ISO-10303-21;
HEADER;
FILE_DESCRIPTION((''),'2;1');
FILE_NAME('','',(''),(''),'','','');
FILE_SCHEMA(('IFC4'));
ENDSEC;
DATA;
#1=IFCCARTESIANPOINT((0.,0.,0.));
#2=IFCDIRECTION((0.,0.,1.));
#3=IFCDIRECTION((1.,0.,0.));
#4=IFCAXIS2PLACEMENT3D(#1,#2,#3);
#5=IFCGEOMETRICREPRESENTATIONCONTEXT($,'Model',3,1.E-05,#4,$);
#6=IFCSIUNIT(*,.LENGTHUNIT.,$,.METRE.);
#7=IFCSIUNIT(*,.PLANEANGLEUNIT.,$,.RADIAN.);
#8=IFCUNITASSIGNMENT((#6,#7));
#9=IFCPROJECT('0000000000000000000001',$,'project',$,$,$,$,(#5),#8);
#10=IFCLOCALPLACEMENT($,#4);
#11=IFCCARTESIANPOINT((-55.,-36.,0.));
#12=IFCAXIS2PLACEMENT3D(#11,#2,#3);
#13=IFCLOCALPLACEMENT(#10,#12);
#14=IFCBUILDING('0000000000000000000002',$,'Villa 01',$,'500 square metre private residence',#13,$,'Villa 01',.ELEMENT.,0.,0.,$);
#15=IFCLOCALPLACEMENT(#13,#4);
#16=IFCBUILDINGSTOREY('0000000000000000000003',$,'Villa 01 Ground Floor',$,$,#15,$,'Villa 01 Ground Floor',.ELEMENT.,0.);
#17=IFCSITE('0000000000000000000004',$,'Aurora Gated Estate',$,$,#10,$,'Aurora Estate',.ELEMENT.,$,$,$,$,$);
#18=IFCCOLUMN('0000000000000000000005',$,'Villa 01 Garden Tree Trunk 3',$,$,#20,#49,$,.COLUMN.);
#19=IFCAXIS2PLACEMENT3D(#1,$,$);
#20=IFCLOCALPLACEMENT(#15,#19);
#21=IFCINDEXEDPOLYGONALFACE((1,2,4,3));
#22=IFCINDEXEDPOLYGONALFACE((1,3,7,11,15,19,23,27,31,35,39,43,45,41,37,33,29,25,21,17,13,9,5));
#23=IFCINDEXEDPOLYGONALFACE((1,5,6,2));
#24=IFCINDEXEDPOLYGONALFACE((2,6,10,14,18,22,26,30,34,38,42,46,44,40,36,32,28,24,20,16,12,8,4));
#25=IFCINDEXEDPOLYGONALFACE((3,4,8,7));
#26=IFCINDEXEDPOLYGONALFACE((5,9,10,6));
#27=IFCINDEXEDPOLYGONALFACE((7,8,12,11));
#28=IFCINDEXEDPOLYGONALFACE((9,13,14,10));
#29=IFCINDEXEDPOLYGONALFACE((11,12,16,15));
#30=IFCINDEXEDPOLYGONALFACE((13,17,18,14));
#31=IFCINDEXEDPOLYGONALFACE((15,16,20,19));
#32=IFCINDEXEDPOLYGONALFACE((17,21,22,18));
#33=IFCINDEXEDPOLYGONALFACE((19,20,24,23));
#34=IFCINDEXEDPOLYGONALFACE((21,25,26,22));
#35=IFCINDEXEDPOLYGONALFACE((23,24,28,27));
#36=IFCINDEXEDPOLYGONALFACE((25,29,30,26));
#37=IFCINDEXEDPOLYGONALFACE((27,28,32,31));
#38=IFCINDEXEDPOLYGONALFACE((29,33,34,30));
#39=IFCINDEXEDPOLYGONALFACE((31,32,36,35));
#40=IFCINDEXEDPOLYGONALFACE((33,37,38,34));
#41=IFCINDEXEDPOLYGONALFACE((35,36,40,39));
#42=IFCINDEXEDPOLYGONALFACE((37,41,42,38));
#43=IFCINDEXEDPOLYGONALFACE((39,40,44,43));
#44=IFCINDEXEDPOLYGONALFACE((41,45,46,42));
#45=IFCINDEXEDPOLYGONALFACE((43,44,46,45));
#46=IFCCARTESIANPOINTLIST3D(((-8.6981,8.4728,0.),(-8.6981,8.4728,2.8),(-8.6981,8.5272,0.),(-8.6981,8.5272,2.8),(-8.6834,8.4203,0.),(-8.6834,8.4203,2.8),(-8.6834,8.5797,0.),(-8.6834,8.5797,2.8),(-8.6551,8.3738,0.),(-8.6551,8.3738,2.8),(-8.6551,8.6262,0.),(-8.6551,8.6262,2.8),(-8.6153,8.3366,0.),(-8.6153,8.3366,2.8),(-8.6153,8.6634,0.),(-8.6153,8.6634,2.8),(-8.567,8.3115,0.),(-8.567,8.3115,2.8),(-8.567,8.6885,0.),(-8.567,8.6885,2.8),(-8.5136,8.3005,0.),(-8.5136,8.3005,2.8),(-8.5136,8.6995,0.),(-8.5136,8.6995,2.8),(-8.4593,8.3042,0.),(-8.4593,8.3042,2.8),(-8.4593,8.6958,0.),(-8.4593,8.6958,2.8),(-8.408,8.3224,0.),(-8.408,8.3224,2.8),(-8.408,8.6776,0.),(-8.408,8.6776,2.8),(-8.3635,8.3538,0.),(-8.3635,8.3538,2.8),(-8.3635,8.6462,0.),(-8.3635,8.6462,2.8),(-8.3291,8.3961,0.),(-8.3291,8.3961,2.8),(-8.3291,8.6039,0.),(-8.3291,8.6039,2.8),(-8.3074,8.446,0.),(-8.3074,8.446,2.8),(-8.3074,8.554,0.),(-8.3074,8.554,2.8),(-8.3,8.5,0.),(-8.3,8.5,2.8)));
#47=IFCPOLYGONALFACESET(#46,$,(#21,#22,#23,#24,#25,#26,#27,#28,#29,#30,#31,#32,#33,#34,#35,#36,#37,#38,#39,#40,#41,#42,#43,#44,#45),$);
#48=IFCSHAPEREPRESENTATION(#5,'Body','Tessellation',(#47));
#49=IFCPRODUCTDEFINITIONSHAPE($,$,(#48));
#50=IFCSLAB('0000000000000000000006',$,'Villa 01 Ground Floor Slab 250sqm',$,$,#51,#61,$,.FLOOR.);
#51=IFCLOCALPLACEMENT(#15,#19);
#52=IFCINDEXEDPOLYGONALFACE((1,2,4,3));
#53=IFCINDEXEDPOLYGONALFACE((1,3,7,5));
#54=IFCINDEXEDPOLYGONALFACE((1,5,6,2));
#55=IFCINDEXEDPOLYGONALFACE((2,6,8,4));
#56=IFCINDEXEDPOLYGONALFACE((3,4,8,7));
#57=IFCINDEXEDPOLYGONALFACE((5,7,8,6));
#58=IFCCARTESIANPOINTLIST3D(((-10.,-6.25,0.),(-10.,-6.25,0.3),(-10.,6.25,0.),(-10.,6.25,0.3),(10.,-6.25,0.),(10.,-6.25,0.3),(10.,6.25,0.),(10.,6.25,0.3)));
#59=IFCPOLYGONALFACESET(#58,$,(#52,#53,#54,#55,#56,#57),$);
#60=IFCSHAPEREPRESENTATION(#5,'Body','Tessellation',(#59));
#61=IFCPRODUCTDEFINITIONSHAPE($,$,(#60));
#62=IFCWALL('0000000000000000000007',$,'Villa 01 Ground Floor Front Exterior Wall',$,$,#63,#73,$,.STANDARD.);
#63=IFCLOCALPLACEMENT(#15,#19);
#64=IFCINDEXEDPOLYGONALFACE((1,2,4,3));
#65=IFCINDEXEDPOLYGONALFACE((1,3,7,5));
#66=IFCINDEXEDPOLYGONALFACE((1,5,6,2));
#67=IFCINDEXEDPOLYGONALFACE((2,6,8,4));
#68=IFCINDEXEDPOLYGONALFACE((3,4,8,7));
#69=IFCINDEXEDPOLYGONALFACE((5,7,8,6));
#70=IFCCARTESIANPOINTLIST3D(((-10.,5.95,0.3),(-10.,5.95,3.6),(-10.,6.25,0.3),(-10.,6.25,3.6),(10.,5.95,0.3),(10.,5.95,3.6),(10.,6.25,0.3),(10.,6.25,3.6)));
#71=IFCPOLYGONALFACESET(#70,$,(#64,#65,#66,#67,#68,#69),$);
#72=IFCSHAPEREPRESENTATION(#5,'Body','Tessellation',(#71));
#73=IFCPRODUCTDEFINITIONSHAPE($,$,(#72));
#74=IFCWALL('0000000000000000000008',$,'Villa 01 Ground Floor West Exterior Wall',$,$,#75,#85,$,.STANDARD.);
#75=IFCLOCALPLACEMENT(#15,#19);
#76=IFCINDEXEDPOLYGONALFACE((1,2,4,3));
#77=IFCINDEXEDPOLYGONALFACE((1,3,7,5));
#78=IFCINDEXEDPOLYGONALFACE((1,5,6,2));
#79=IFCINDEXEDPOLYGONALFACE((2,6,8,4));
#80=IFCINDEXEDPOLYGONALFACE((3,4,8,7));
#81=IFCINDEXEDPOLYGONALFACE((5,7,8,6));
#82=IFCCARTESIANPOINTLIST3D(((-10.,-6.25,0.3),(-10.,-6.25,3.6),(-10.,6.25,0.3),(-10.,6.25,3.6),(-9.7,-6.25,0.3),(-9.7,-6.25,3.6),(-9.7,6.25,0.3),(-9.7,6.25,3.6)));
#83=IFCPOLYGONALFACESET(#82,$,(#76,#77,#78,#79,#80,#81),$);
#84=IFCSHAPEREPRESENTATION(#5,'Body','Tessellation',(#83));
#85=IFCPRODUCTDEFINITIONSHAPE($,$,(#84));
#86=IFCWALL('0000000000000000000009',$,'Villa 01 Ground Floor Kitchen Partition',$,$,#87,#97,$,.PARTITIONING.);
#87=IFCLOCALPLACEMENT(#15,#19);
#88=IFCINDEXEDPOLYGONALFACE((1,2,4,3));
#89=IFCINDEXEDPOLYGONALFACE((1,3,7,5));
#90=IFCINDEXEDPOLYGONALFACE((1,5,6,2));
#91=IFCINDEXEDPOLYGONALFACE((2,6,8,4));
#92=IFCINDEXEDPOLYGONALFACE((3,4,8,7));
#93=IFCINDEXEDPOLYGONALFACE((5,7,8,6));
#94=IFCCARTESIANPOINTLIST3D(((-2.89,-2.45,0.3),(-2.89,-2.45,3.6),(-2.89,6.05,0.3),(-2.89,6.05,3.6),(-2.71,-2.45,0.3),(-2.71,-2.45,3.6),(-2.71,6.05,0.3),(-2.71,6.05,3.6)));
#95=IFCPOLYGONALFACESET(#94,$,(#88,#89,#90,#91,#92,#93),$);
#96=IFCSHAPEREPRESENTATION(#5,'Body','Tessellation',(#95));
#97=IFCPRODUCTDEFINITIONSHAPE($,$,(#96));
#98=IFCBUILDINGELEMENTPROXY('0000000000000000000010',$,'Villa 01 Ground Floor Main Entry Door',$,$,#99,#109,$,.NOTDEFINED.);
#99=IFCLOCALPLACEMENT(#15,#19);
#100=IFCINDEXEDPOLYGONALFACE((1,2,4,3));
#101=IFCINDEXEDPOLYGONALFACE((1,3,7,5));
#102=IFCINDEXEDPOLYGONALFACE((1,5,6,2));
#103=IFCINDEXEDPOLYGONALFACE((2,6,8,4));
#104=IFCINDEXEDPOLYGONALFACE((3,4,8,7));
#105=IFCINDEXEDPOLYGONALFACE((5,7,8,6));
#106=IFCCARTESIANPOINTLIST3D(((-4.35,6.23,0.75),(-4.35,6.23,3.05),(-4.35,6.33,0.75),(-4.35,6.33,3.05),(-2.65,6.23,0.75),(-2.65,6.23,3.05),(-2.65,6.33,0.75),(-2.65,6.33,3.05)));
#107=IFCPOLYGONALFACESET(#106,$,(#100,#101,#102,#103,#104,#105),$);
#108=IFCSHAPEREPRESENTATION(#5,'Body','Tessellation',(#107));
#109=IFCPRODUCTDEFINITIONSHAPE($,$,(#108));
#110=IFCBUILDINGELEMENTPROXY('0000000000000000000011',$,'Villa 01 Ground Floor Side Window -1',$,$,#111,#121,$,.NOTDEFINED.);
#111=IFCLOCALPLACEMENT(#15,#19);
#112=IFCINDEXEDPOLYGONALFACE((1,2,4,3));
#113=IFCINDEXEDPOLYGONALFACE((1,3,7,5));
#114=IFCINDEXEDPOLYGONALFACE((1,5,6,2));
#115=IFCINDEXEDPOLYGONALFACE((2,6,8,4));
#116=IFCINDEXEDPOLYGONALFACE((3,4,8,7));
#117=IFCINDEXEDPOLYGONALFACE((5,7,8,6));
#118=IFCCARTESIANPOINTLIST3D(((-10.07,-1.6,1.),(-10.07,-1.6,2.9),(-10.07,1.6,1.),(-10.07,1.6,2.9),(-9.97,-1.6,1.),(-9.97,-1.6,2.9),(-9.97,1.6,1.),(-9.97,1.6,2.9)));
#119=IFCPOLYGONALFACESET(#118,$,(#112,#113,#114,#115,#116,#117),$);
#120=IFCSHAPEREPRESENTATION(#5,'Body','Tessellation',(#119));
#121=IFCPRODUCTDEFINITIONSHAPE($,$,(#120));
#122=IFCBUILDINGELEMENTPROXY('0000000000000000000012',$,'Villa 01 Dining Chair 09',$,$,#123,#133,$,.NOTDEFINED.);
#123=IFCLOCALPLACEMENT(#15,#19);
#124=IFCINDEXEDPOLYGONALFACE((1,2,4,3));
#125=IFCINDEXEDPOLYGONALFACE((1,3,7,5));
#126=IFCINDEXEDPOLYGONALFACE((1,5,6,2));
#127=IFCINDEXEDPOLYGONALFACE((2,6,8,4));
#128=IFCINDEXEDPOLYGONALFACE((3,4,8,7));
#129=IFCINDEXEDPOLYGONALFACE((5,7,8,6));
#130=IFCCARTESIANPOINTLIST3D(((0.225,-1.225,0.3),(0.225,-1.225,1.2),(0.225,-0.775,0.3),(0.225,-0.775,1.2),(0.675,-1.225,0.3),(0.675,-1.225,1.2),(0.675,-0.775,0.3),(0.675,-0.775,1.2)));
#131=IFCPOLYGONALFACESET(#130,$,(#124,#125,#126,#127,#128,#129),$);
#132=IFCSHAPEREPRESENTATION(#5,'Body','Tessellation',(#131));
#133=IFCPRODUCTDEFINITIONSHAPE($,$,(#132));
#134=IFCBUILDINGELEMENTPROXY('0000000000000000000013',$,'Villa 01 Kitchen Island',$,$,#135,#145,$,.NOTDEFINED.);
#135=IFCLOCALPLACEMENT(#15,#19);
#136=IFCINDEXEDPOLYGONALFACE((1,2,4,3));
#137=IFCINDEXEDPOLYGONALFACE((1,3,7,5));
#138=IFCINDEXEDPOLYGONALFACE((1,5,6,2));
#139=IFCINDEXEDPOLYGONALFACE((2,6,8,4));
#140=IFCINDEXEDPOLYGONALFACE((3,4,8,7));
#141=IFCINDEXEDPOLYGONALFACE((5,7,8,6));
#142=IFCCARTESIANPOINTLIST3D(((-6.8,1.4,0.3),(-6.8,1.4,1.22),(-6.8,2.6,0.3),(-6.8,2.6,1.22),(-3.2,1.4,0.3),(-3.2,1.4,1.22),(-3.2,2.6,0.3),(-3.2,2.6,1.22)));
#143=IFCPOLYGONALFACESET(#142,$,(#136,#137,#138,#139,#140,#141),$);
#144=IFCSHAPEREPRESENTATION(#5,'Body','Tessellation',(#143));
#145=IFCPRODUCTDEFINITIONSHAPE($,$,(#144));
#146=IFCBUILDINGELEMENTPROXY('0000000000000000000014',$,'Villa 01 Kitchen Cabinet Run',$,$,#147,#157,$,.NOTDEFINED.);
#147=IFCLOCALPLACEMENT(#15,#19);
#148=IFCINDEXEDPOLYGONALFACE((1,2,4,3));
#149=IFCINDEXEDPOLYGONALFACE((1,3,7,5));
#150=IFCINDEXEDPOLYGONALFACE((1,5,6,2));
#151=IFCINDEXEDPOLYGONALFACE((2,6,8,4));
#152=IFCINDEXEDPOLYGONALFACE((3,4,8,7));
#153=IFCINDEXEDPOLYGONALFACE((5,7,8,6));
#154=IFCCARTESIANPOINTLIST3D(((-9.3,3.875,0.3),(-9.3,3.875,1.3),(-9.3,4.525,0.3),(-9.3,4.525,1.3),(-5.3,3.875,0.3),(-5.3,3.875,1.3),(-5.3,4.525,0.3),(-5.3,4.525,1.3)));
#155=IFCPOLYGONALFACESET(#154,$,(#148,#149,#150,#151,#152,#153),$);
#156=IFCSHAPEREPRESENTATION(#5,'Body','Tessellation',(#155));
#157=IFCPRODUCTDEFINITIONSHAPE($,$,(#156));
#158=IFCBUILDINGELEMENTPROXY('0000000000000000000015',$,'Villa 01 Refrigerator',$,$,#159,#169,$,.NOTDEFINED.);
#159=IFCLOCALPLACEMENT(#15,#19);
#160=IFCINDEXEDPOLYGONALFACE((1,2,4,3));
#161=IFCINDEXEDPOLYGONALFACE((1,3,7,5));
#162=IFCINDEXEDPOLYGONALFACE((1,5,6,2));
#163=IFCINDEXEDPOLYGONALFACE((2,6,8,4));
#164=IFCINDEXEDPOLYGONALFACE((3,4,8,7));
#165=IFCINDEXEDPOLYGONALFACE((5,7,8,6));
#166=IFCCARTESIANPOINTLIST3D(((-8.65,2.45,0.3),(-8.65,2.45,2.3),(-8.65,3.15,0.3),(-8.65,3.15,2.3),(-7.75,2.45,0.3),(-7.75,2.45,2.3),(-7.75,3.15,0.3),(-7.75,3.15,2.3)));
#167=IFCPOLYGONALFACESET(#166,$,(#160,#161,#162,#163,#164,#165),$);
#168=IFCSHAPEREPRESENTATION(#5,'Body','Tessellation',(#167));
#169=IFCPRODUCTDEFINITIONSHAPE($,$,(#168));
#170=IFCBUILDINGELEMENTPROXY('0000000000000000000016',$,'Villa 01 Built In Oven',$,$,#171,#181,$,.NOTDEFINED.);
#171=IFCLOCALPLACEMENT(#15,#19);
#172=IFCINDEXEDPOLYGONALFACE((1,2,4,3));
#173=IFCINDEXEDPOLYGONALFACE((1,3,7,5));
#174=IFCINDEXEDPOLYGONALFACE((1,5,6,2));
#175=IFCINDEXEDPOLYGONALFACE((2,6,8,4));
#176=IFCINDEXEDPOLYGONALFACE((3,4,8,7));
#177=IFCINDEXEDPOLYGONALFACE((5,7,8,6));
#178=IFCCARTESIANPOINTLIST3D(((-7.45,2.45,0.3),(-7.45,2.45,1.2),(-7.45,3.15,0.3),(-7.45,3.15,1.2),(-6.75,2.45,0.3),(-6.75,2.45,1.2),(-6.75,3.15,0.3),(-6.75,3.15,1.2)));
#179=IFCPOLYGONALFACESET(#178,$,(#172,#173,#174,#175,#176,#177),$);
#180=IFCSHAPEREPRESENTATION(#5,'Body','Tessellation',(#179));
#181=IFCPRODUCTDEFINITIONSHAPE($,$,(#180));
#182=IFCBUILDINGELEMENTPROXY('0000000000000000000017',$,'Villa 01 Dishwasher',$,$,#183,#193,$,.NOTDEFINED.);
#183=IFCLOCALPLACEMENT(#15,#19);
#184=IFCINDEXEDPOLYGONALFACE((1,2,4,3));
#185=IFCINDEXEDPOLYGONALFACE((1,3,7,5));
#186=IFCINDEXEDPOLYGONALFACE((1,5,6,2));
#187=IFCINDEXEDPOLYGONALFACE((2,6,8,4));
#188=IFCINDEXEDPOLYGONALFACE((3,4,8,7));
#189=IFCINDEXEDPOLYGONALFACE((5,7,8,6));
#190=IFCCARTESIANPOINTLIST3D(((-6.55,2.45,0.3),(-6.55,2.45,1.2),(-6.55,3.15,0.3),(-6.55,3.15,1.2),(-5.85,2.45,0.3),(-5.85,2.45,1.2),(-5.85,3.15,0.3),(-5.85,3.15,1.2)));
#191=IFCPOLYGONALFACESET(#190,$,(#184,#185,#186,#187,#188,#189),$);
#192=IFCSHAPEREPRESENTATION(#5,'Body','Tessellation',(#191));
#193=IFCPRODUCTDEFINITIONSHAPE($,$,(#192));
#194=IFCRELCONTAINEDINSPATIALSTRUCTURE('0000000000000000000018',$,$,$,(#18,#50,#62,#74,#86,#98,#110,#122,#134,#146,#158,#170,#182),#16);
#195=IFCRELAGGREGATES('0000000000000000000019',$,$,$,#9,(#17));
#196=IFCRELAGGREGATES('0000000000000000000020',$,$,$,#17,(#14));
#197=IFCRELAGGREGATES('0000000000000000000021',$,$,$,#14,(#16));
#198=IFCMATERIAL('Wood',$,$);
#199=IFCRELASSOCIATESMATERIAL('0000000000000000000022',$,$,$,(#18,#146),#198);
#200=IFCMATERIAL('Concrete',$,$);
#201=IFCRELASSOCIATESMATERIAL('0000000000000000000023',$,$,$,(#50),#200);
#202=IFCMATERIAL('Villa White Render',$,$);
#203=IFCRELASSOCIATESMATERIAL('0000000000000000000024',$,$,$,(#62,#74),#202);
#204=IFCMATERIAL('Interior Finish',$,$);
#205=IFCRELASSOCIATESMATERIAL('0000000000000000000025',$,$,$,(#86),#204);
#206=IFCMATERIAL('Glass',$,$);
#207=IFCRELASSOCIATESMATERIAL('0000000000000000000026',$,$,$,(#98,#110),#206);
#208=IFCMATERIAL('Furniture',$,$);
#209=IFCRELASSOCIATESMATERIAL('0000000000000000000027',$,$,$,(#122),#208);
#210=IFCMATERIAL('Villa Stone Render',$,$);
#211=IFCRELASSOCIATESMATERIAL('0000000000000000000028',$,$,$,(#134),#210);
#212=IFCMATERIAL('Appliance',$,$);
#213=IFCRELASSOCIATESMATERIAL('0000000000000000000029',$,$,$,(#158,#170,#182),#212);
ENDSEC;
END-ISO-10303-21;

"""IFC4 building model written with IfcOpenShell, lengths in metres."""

from ifc_helpers import new_model, si_unit, frame, origin_with_axes, origin_2d_with_axis, place, context, project, spatial, rectangle, circle, extrude, material, element, save


model = new_model("IFC4")

# Units and contexts
model_context = context("Model", 3, precision=1e-05, world=origin_with_axes())
ifc_project = project(units=[si_unit("LENGTHUNIT", "METRE"), si_unit("PLANEANGLEUNIT", "RADIAN")], contexts=[model_context])

# Site, building, storey
site_placement = place(None, origin_with_axes())
site = spatial("IfcSite", under=ifc_project, at=site_placement, Name="Aurora Gated Estate", LongName="Aurora Estate", CompositionType="ELEMENT")
building_placement = place(site_placement, frame((-55.0, -36.0, 0.0), z_axis=(0.0, 0.0, 1.0), x_axis=(1.0, 0.0, 0.0)))
building = spatial("IfcBuilding", under=site, at=building_placement, Name="Villa 01", ObjectType="500 square metre private residence", LongName="Villa 01", CompositionType="ELEMENT", ElevationOfRefHeight=0.0, ElevationOfTerrain=0.0)
storey_placement = place(building_placement, origin_with_axes())
storey = spatial("IfcBuildingStorey", under=building, at=storey_placement, Name="Villa 01 Ground Floor", LongName="Villa 01 Ground Floor", CompositionType="ELEMENT", Elevation=0.0)

# Column
ifc_material_1 = material(Name="Wood")
column_placement = place(storey_placement, frame((-8.5, 8.5, 0.0), z_axis=(0.0, 0.0, 1.0), x_axis=(1.0, 0.0, 0.0)))
element("IfcColumn", 1, at=column_placement, inside=storey, material=ifc_material_1, Name="Villa 01 Garden Tree Trunk 3", PredefinedType="COLUMN", context=model_context, shape_type="SweptSolid", body=[
    extrude(circle(Radius=0.2, at=origin_2d_with_axis()), origin_with_axes(), (0.0, 0.0, 1.0), 2.8),
])

# Slab
ifc_material_2 = material(Name="Concrete")
slab_placement = place(storey_placement, origin_with_axes())
element("IfcSlab", 2, at=slab_placement, inside=storey, material=ifc_material_2, Name="Villa 01 Ground Floor Slab 250sqm", PredefinedType="FLOOR", context=model_context, shape_type="SweptSolid", body=[
    extrude(rectangle(XDim=20.0, YDim=12.5, at=origin_2d_with_axis()), origin_with_axes(), (0.0, 0.0, 1.0), 0.3),
])

# Walls
ifc_material_3 = material(Name="Villa White Render")
wall_1_placement = place(storey_placement, frame((0.0, 6.1, 0.3), z_axis=(0.0, 0.0, 1.0), x_axis=(1.0, 0.0, 0.0)))
element("IfcWall", 3, at=wall_1_placement, inside=storey, material=ifc_material_3, Name="Villa 01 Ground Floor Front Exterior Wall", PredefinedType="STANDARD", context=model_context, shape_type="SweptSolid", body=[
    extrude(rectangle(XDim=20.0, YDim=0.3, at=origin_2d_with_axis()), origin_with_axes(), (0.0, 0.0, 1.0), 3.3),
])
wall_2_placement = place(storey_placement, frame((-9.85, 0.0, 0.3), z_axis=(0.0, 0.0, 1.0), x_axis=(1.0, 0.0, 0.0)))
element("IfcWall", 4, at=wall_2_placement, inside=storey, material=ifc_material_3, Name="Villa 01 Ground Floor West Exterior Wall", PredefinedType="STANDARD", context=model_context, shape_type="SweptSolid", body=[
    extrude(rectangle(XDim=0.3, YDim=12.5, at=origin_2d_with_axis()), origin_with_axes(), (0.0, 0.0, 1.0), 3.3),
])
ifc_material_4 = material(Name="Interior Finish")
wall_3_placement = place(storey_placement, frame((-2.8, 1.8, 0.3), z_axis=(0.0, 0.0, 1.0), x_axis=(1.0, 0.0, 0.0)))
element("IfcWall", 5, at=wall_3_placement, inside=storey, material=ifc_material_4, Name="Villa 01 Ground Floor Kitchen Partition", PredefinedType="PARTITIONING", context=model_context, shape_type="SweptSolid", body=[
    extrude(rectangle(XDim=0.18, YDim=8.5, at=origin_2d_with_axis()), origin_with_axes(), (0.0, 0.0, 1.0), 3.3),
])

# Building element proxies
ifc_material_5 = material(Name="Glass")
proxy_1_placement = place(storey_placement, frame((-3.5, 6.28, 0.75), z_axis=(0.0, 0.0, 1.0), x_axis=(1.0, 0.0, 0.0)))
element("IfcBuildingElementProxy", 6, at=proxy_1_placement, inside=storey, material=ifc_material_5, Name="Villa 01 Ground Floor Main Entry Door", PredefinedType="NOTDEFINED", context=model_context, shape_type="SweptSolid", body=[
    extrude(rectangle(XDim=1.7, YDim=0.1, at=origin_2d_with_axis()), origin_with_axes(), (0.0, 0.0, 1.0), 2.3),
])
proxy_2_placement = place(storey_placement, frame((-10.02, 0.0, 1.0), z_axis=(0.0, 0.0, 1.0), x_axis=(0.0, 1.0, 0.0)))
element("IfcBuildingElementProxy", 7, at=proxy_2_placement, inside=storey, material=ifc_material_5, Name="Villa 01 Ground Floor Side Window -1", PredefinedType="NOTDEFINED", context=model_context, shape_type="SweptSolid", body=[
    extrude(rectangle(XDim=3.2, YDim=0.1, at=origin_2d_with_axis()), origin_with_axes(), (0.0, 0.0, 1.0), 1.9),
])
ifc_material_6 = material(Name="Furniture")
proxy_3_placement = place(storey_placement, frame((0.45, -1.0, 0.3), z_axis=(0.0, 0.0, 1.0), x_axis=(1.0, 0.0, 0.0)))
element("IfcBuildingElementProxy", 8, at=proxy_3_placement, inside=storey, material=ifc_material_6, Name="Villa 01 Dining Chair 09", PredefinedType="NOTDEFINED", context=model_context, shape_type="SweptSolid", body=[
    extrude(rectangle(XDim=0.45, YDim=0.45, at=origin_2d_with_axis()), origin_with_axes(), (0.0, 0.0, 1.0), 0.9),
])
ifc_material_7 = material(Name="Villa Stone Render")
proxy_4_placement = place(storey_placement, frame((-5.0, 2.0, 0.3), z_axis=(0.0, 0.0, 1.0), x_axis=(1.0, 0.0, 0.0)))
element("IfcBuildingElementProxy", 9, at=proxy_4_placement, inside=storey, material=ifc_material_7, Name="Villa 01 Kitchen Island", PredefinedType="NOTDEFINED", context=model_context, shape_type="SweptSolid", body=[
    extrude(rectangle(XDim=3.6, YDim=1.2, at=origin_2d_with_axis()), origin_with_axes(), (0.0, 0.0, 1.0), 0.92),
])
proxy_5_placement = place(storey_placement, frame((-7.3, 4.2, 0.3), z_axis=(0.0, 0.0, 1.0), x_axis=(1.0, 0.0, 0.0)))
element("IfcBuildingElementProxy", 10, at=proxy_5_placement, inside=storey, material=ifc_material_1, Name="Villa 01 Kitchen Cabinet Run", PredefinedType="NOTDEFINED", context=model_context, shape_type="SweptSolid", body=[
    extrude(rectangle(XDim=4.0, YDim=0.65, at=origin_2d_with_axis()), origin_with_axes(), (0.0, 0.0, 1.0), 1.0),
])
ifc_material_8 = material(Name="Appliance")
proxy_6_placement = place(storey_placement, frame((-8.2, 2.8, 0.3), z_axis=(0.0, 0.0, 1.0), x_axis=(1.0, 0.0, 0.0)))
element("IfcBuildingElementProxy", 11, at=proxy_6_placement, inside=storey, material=ifc_material_8, Name="Villa 01 Refrigerator", PredefinedType="NOTDEFINED", context=model_context, shape_type="SweptSolid", body=[
    extrude(rectangle(XDim=0.9, YDim=0.7, at=origin_2d_with_axis()), origin_with_axes(), (0.0, 0.0, 1.0), 2.0),
])
for number, where, z_axis, x_axis, name in (
    (12, (-7.1, 2.8, 0.3), (0.0, 0.0, 1.0), (1.0, 0.0, 0.0), "Villa 01 Built In Oven"),
    (13, (-6.2, 2.8, 0.3), (0.0, 0.0, 1.0), (1.0, 0.0, 0.0), "Villa 01 Dishwasher"),
):
    element("IfcBuildingElementProxy", number, at=place(storey_placement, frame(where, z_axis=z_axis, x_axis=x_axis)), inside=storey, material=ifc_material_8, Name=name, PredefinedType="NOTDEFINED", context=model_context, shape_type="SweptSolid", body=[
        extrude(rectangle(XDim=0.7, YDim=0.7, at=origin_2d_with_axis()), origin_with_axes(), (0.0, 0.0, 1.0), 0.9),
    ])

save(model, "model.ifc")
